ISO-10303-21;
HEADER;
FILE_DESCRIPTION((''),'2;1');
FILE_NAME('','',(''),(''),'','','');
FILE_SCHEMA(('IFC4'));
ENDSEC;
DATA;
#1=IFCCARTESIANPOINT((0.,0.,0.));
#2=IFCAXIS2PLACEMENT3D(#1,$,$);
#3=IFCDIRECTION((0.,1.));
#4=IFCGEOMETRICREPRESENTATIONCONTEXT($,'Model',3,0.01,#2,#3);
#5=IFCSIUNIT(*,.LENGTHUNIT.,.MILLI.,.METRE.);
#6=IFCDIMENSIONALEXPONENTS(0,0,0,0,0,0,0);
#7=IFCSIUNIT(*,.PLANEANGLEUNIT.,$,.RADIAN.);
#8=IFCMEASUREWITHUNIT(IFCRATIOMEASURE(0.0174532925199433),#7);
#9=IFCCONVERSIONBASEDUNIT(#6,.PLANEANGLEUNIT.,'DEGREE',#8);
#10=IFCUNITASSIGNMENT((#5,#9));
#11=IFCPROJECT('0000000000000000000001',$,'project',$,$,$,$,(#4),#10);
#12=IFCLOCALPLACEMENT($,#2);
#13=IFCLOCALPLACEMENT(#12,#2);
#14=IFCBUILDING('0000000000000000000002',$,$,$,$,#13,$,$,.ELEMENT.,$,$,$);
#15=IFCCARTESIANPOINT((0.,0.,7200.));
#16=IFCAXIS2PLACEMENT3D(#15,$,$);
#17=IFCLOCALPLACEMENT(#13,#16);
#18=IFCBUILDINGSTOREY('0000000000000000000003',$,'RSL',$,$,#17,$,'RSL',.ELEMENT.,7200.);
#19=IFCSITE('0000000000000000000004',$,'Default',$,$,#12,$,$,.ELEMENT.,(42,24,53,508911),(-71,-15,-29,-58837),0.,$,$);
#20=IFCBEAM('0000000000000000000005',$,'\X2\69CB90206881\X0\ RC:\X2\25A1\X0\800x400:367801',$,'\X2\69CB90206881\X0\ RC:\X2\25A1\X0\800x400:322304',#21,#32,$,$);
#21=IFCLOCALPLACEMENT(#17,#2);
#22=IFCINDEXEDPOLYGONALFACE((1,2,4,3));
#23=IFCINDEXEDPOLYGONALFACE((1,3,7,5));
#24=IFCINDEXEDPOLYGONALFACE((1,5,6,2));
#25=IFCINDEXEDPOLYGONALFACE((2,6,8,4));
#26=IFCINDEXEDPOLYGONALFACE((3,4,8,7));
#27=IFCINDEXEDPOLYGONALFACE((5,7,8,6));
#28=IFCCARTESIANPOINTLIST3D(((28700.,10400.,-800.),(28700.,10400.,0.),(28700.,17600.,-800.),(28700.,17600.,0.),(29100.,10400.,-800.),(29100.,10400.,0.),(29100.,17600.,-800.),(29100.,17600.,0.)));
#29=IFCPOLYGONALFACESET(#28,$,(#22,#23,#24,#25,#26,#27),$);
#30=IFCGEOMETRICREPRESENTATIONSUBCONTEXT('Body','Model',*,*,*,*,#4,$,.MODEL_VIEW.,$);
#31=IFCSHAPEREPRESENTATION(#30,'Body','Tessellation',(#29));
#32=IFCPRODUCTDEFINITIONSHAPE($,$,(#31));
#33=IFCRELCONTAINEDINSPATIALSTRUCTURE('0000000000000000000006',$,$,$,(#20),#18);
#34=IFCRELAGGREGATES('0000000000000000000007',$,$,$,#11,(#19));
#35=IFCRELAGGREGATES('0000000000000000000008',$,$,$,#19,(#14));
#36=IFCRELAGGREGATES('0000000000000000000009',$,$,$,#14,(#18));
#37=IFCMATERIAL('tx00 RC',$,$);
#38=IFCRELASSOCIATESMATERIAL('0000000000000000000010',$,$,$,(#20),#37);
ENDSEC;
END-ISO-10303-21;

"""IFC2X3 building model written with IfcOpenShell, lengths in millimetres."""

from ifc_helpers import new_model, entity, si_unit, converted_unit, direction, frame, frame_2d, origin, place, context, subcontext, project, spatial, rectangle, extrude, material, element, save


model = new_model("IFC2X3")

# Units and contexts
model_context = context("Model", 3, precision=0.01, world=origin(), true_north=direction((0.0, 1.0)))
body_context = subcontext(model_context, "Body", "Model", "MODEL_VIEW")
ifc_project = project(units=[si_unit("LENGTHUNIT", "METRE", prefix="MILLI"), converted_unit("PLANEANGLEUNIT", "DEGREE", entity("IfcRatioMeasure", 0.0174532925199433), si_unit("PLANEANGLEUNIT", "RADIAN"), dimensions=[0, 0, 0, 0, 0, 0, 0])], contexts=[model_context])

# Site, building, storey
site_placement = place(None, origin())
site = spatial("IfcSite", under=ifc_project, at=site_placement, Name="Default", CompositionType="ELEMENT", RefLatitude=(42, 24, 53, 508911), RefLongitude=(-71, -15, -29, -58837), RefElevation=0.0)
building_placement = place(site_placement, origin())
building = spatial("IfcBuilding", under=site, at=building_placement, CompositionType="ELEMENT")
storey_placement = place(building_placement, frame((0.0, 0.0, 7200.0)))
storey = spatial("IfcBuildingStorey", under=building, at=storey_placement, Name="RSL", LongName="RSL", CompositionType="ELEMENT", Elevation=7200.0)

# Beam
ifc_material_1 = material(Name="tx00 RC")
beam_1_placement = place(storey_placement, frame((28900.0, 18000.0, 0.0), z_axis=(0.0, 0.0, 1.0), x_axis=(0.0, -1.0, 0.0)))
element("IfcBeam", 1, at=beam_1_placement, inside=storey, material=ifc_material_1, Name="構造梁 RC:□800x400:367801", ObjectType="構造梁 RC:□800x400:322304", context=body_context, shape_type="SweptSolid", body=[
    extrude(rectangle(XDim=800.0, YDim=400.0, at=frame_2d((0.0, 0.0), x_axis=(1.0, 0.0))), frame((400.0, 0.0, -400.0), z_axis=(1.0, 0.0, 0.0), x_axis=(0.0, 0.0, -1.0)), (0.0, 0.0, 1.0), 7200.0),
])

save(model, "model.ifc")
